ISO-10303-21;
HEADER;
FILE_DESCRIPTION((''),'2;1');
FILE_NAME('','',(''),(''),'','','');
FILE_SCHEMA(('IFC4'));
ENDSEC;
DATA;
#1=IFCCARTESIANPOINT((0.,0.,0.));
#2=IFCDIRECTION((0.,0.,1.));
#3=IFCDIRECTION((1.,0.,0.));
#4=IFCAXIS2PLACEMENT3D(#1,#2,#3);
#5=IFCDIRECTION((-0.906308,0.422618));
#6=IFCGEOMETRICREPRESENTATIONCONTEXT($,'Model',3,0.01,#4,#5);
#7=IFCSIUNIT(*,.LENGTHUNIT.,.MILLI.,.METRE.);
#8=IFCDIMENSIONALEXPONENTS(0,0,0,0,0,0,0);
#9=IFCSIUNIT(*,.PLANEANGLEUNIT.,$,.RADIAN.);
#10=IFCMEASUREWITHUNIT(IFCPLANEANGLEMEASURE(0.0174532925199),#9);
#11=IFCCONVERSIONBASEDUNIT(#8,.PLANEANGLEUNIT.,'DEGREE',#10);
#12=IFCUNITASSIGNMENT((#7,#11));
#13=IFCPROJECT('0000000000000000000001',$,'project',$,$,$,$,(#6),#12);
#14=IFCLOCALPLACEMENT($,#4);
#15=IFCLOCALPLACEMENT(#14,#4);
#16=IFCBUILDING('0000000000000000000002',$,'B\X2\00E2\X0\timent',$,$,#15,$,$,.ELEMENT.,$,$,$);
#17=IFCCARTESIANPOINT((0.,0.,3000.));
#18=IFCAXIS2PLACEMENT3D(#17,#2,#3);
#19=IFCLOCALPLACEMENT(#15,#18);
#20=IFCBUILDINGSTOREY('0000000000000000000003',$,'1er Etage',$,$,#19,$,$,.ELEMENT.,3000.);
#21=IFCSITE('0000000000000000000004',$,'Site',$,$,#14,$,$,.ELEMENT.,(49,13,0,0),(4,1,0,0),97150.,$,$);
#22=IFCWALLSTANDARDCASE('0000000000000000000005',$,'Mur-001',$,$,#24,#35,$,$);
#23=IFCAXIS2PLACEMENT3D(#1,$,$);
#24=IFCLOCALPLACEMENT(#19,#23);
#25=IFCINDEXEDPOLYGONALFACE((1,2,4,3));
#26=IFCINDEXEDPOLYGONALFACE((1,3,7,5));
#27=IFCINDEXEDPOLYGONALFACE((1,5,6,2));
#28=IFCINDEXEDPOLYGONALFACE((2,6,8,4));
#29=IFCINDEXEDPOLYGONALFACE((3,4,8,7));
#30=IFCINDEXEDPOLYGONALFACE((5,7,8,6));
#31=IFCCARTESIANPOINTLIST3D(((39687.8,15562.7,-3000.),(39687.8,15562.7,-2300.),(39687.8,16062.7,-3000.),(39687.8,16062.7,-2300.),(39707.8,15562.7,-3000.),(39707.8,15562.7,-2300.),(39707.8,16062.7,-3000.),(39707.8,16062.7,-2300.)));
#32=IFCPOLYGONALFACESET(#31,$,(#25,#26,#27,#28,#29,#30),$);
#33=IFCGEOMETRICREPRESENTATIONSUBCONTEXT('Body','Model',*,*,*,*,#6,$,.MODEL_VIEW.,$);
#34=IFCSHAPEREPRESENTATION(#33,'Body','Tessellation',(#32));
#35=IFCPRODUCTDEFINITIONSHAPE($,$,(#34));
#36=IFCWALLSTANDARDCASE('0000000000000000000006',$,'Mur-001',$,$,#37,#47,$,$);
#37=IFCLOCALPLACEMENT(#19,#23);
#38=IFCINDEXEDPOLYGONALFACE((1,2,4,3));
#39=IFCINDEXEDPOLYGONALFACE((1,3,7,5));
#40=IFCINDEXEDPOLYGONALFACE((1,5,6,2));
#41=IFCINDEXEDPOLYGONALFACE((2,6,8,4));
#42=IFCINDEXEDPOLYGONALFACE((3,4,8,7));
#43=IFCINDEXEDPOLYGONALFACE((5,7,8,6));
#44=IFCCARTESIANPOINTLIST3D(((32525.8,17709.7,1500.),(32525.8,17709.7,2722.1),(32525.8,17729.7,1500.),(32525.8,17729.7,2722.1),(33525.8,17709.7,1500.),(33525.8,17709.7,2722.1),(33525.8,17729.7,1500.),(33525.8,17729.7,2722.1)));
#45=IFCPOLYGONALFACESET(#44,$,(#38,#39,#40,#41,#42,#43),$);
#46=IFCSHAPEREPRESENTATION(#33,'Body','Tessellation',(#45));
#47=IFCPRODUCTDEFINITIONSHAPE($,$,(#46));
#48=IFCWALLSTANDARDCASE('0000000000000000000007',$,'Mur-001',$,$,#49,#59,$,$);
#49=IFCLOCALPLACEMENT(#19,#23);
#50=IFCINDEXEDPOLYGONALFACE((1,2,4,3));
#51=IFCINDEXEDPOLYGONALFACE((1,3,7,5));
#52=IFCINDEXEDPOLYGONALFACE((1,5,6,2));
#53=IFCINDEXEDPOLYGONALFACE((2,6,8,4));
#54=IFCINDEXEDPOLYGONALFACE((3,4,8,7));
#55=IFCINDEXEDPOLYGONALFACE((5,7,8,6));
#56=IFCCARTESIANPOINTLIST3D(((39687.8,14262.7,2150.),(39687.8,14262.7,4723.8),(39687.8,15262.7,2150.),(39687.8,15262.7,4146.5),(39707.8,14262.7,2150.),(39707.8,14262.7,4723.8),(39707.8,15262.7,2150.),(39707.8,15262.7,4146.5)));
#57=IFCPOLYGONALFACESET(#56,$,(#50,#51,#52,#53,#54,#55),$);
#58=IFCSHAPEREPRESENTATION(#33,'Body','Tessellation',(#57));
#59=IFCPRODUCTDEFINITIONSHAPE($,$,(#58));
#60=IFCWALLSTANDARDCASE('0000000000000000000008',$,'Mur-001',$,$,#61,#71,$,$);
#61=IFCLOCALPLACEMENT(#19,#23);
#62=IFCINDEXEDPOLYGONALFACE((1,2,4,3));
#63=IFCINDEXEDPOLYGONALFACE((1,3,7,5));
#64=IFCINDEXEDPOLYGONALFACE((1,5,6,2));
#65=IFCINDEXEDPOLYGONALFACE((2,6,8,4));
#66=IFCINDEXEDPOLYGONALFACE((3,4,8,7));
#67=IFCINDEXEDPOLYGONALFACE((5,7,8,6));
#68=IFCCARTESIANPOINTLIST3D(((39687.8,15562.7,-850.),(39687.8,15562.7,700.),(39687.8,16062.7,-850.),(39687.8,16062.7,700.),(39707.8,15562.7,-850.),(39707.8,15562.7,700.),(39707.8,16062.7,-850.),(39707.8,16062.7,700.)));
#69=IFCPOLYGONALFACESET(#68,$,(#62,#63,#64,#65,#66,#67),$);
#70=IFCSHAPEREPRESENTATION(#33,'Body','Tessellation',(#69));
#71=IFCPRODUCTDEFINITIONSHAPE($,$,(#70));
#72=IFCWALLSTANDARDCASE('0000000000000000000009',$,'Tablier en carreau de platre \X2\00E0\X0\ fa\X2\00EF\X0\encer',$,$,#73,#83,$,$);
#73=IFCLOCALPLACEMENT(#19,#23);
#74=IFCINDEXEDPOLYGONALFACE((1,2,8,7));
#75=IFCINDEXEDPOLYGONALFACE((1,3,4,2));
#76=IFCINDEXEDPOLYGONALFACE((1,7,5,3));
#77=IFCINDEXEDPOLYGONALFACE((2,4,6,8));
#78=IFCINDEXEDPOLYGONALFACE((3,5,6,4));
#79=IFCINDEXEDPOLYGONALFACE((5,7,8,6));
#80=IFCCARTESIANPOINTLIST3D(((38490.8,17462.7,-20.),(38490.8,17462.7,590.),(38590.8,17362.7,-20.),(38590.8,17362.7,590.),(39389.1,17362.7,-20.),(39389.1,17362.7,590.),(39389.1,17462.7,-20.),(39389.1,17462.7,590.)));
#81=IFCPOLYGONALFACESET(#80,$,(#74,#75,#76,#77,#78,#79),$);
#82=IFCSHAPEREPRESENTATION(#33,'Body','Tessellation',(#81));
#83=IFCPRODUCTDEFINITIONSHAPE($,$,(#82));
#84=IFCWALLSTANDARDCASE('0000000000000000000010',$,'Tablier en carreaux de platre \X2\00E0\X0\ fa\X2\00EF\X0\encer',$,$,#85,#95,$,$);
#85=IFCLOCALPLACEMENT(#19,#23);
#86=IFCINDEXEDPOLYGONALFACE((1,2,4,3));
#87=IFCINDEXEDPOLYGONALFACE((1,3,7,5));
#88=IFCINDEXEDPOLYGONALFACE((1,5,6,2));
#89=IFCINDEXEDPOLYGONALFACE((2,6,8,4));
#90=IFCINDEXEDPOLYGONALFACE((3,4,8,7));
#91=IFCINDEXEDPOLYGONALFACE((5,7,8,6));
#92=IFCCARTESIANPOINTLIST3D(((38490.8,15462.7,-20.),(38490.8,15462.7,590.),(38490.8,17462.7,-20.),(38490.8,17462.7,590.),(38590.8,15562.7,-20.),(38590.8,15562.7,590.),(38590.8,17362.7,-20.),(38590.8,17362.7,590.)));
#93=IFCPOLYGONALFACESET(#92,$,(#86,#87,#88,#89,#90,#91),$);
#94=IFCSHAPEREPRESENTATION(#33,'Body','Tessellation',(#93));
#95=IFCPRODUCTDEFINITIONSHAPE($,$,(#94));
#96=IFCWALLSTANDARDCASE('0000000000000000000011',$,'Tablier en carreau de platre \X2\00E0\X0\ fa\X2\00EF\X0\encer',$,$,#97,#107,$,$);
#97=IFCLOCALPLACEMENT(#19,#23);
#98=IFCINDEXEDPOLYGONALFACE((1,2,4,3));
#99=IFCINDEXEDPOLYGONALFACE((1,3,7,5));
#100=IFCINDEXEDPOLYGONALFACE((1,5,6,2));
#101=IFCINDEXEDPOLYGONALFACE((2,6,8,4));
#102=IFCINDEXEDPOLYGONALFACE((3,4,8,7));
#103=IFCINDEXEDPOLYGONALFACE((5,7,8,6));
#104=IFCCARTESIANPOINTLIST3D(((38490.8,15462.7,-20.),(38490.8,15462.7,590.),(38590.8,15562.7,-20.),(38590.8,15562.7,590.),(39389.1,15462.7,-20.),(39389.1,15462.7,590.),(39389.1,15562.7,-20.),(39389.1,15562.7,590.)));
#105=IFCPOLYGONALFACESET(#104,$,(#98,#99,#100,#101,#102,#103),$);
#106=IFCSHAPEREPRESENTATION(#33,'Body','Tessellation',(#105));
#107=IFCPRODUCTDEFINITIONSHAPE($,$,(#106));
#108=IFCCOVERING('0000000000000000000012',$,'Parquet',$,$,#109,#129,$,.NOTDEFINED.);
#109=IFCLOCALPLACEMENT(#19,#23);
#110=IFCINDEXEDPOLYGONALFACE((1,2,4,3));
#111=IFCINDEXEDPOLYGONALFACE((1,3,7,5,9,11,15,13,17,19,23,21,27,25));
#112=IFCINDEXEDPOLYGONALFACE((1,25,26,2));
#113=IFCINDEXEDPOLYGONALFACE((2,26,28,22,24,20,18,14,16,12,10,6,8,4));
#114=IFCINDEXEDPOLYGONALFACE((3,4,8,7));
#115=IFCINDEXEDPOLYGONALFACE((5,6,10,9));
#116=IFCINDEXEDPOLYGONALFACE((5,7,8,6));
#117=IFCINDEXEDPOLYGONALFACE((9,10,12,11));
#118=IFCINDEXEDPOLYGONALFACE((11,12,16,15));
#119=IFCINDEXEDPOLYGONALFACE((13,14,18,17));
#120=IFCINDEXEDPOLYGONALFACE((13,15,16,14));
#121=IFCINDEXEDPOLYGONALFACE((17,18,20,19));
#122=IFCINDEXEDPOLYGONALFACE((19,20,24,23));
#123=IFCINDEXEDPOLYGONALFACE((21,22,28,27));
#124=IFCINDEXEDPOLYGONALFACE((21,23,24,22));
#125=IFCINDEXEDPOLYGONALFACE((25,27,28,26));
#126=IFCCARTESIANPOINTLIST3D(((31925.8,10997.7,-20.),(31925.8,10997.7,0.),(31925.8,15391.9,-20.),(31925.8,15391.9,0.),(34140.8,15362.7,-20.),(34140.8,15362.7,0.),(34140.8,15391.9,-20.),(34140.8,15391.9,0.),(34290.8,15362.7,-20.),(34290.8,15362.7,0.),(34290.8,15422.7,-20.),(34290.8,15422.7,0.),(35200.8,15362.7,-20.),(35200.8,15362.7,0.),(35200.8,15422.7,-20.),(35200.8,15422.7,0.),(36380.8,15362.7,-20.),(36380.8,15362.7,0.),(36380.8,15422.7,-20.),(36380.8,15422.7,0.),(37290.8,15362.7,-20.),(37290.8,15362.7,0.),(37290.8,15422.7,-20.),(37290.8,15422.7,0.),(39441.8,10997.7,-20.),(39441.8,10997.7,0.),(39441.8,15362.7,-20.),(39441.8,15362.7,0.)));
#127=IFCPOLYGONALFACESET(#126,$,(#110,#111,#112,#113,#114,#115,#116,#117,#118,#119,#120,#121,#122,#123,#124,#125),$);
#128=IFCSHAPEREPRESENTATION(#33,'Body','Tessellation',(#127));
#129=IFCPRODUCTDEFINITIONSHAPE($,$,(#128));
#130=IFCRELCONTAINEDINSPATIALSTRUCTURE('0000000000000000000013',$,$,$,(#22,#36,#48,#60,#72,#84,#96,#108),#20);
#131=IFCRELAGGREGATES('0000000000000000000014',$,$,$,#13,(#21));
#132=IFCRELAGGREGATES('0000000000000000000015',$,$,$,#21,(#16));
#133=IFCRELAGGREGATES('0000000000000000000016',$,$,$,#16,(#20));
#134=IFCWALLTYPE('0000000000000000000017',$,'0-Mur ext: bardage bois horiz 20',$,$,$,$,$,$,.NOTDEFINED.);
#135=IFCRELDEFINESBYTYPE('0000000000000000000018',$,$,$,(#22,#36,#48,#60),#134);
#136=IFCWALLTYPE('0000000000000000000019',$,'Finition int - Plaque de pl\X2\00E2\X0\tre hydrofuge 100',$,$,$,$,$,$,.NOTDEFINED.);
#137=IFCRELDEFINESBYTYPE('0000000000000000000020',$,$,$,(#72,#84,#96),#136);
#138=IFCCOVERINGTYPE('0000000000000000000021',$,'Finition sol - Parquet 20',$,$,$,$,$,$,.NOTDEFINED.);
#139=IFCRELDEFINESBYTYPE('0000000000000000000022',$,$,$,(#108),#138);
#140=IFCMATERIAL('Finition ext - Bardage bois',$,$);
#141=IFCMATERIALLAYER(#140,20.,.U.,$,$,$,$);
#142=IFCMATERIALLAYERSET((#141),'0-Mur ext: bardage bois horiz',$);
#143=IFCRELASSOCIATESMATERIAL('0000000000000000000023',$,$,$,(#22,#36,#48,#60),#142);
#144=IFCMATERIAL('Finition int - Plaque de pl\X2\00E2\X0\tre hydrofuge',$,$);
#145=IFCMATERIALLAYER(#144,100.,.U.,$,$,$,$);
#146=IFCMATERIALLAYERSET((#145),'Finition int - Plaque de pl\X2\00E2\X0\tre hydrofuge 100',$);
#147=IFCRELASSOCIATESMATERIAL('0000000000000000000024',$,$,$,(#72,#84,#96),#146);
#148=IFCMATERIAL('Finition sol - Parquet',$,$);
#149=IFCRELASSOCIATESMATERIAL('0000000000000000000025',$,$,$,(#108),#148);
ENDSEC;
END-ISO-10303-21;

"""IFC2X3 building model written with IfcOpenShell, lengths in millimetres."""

from ifc_helpers import new_model, entity, si_unit, converted_unit, direction, frame, origin_with_axes, place, context, subcontext, project, spatial, polyline, outline, extrude, clip, halfspace, material, layer, layer_set, layer_usage, type_object, element, save


model = new_model("IFC2X3")

# Units and contexts
model_context = context("Model", 3, precision=0.01, world=origin_with_axes(), true_north=direction((-0.906308, 0.422618)))
body_context = subcontext(model_context, "Body", "Model", "MODEL_VIEW")
ifc_project = project(units=[si_unit("LENGTHUNIT", "METRE", prefix="MILLI"), converted_unit("PLANEANGLEUNIT", "DEGREE", entity("IfcPlaneAngleMeasure", 0.0174532925199), si_unit("PLANEANGLEUNIT", "RADIAN"), dimensions=[0, 0, 0, 0, 0, 0, 0])], contexts=[model_context])

# Site, building, storey
site_placement = place(None, origin_with_axes())
site = spatial("IfcSite", under=ifc_project, at=site_placement, Name="Site", CompositionType="ELEMENT", RefLatitude=(49, 13, 0, 0), RefLongitude=(4, 1, 0, 0), RefElevation=97150.0)
building_placement = place(site_placement, origin_with_axes())
building = spatial("IfcBuilding", under=site, at=building_placement, Name="Bâtiment", CompositionType="ELEMENT")
storey_placement = place(building_placement, frame((0.0, 0.0, 3000.0), z_axis=(0.0, 0.0, 1.0), x_axis=(1.0, 0.0, 0.0)))
storey = spatial("IfcBuildingStorey", under=building, at=storey_placement, Name="1er Etage", CompositionType="ELEMENT", Elevation=3000.0)

# Walls
ifc_material_1 = material(Name="Finition ext - Bardage bois")
ifc_layer_1 = layer(ifc_material_1, 20.0, ventilated="UNKNOWN")
ifc_layer_set_1 = layer_set([ifc_layer_1], Name="0-Mur ext: bardage bois horiz")
ifc_layer_usage_1 = layer_usage(ifc_layer_set_1, "AXIS2", "POSITIVE", 0.0)
wall_type_1 = type_object("IfcWallType", Name="0-Mur ext: bardage bois horiz 20", PredefinedType="NOTDEFINED")
wall_1_placement = place(storey_placement, frame((39707.8, 15562.7, -3000.0), z_axis=(0.0, 0.0, 1.0), x_axis=(0.0, 1.0, 0.0)))
element("IfcWallStandardCase", 1, at=wall_1_placement, inside=storey, type_object=wall_type_1, material=ifc_layer_usage_1, Name="Mur-001", context=body_context, shape_type="SweptSolid", body=[
    extrude(outline(polyline([(0.0, 0.0), (500.0, 0.0), (500.0, 20.0), (0.0, 20.0), (0.0, 0.0)])), origin_with_axes(), (0.0, 0.0, 1.0), 700.0),
])
ifc_layer_usage_2 = layer_usage(ifc_layer_set_1, "AXIS2", "NEGATIVE", 0.0)
wall_2_placement = place(storey_placement, frame((32525.8, 17729.7, 1500.0), z_axis=(0.0, 0.0, 1.0), x_axis=(1.0, 0.0, 0.0)))
element("IfcWallStandardCase", 2, at=wall_2_placement, inside=storey, type_object=wall_type_1, material=ifc_layer_usage_2, Name="Mur-001", context=body_context, shape_type="SweptSolid", body=[
    extrude(outline(polyline([(0.0, -20.0), (1000.0, -20.0), (1000.0, 0.0), (0.0, 0.0), (0.0, -20.0)])), origin_with_axes(), (0.0, 0.0, 1.0), 1222.1),
])
ifc_layer_usage_3 = layer_usage(ifc_layer_set_1, "AXIS2", "POSITIVE", 0.0)
wall_3_placement = place(storey_placement, frame((39707.8, 14262.7, 2150.0), z_axis=(0.0, 0.0, 1.0), x_axis=(0.0, 1.0, 0.0)))
element("IfcWallStandardCase", 3, at=wall_3_placement, inside=storey, type_object=wall_type_1, material=ifc_layer_usage_3, Name="Mur-001", context=body_context, shape_type="Clipping", body=[
    clip(extrude(outline(polyline([(0.0, 0.0), (1000.0, 0.0), (1000.0, 20.0), (0.0, 20.0), (0.0, 0.0)])), origin_with_axes(), (0.0, 0.0, 1.0), 3050.0), halfspace(frame((1114.5, 0.0, 1930.4), z_axis=(-0.5, 0.0, -0.866025), x_axis=(0.0, 1.0, 0.0)), True)),
])
ifc_layer_usage_4 = layer_usage(ifc_layer_set_1, "AXIS2", "POSITIVE", 0.0)
wall_4_placement = place(storey_placement, frame((39707.8, 15562.7, -850.0), z_axis=(0.0, 0.0, 1.0), x_axis=(0.0, 1.0, 0.0)))
element("IfcWallStandardCase", 4, at=wall_4_placement, inside=storey, type_object=wall_type_1, material=ifc_layer_usage_4, Name="Mur-001", context=body_context, shape_type="SweptSolid", body=[
    extrude(outline(polyline([(0.0, 0.0), (500.0, 0.0), (500.0, 20.0), (0.0, 20.0), (0.0, 0.0)])), origin_with_axes(), (0.0, 0.0, 1.0), 1550.0),
])
ifc_material_2 = material(Name="Finition int - Plaque de plâtre hydrofuge")
ifc_layer_2 = layer(ifc_material_2, 100.0, ventilated="UNKNOWN")
ifc_layer_set_2 = layer_set([ifc_layer_2], Name="Finition int - Plaque de plâtre hydrofuge 100")
ifc_layer_usage_5 = layer_usage(ifc_layer_set_2, "AXIS2", "POSITIVE", -100.0)
wall_type_2 = type_object("IfcWallType", Name="Finition int - Plaque de plâtre hydrofuge 100", PredefinedType="NOTDEFINED")
wall_5_placement = place(storey_placement, frame((39389.1, 17362.7, -20.0), z_axis=(0.0, 0.0, 1.0), x_axis=(-1.0, 0.0, 0.0)))
element("IfcWallStandardCase", 5, at=wall_5_placement, inside=storey, type_object=wall_type_2, material=ifc_layer_usage_5, Name="Tablier en carreau de platre à faïencer", context=body_context, shape_type="SweptSolid", body=[
    extrude(outline(polyline([(0.0, -100.0), (898.2, -100.0), (798.2, 0.0), (0.0, 0.0), (0.0, -100.0)])), origin_with_axes(), (0.0, 0.0, 1.0), 610.0),
])
ifc_layer_usage_6 = layer_usage(ifc_layer_set_2, "AXIS2", "POSITIVE", -100.0)
wall_6_placement = place(storey_placement, frame((38590.8, 17362.7, -20.0), z_axis=(0.0, 0.0, 1.0), x_axis=(0.0, -1.0, 0.0)))
element("IfcWallStandardCase", 6, at=wall_6_placement, inside=storey, type_object=wall_type_2, material=ifc_layer_usage_6, Name="Tablier en carreaux de platre à faïencer", context=body_context, shape_type="SweptSolid", body=[
    extrude(outline(polyline([(-100.0, -100.0), (1900.0, -100.0), (1800.0, 0.0), (0.0, 0.0), (-100.0, -100.0)])), origin_with_axes(), (0.0, 0.0, 1.0), 610.0),
])
ifc_layer_usage_7 = layer_usage(ifc_layer_set_2, "AXIS2", "POSITIVE", -100.0)
wall_7_placement = place(storey_placement, frame((38590.8, 15562.7, -20.0), z_axis=(0.0, 0.0, 1.0), x_axis=(1.0, 0.0, 0.0)))
element("IfcWallStandardCase", 7, at=wall_7_placement, inside=storey, type_object=wall_type_2, material=ifc_layer_usage_7, Name="Tablier en carreau de platre à faïencer", context=body_context, shape_type="SweptSolid", body=[
    extrude(outline(polyline([(-100.0, -100.0), (798.2, -100.0), (798.2, 0.0), (0.0, 0.0), (-100.0, -100.0)])), origin_with_axes(), (0.0, 0.0, 1.0), 610.0),
])

# Covering
ifc_material_3 = material(Name="Finition sol - Parquet")
covering_type = type_object("IfcCoveringType", Name="Finition sol - Parquet 20", PredefinedType="NOTDEFINED")
covering_placement = place(storey_placement, frame((31925.8, 15391.9, 0.0), z_axis=(0.0, 0.0, 1.0), x_axis=(1.0, 0.0, 0.0)))
element("IfcCovering", 8, at=covering_placement, inside=storey, type_object=covering_type, material=ifc_material_3, Name="Parquet", PredefinedType="NOTDEFINED", context=body_context, shape_type="SweptSolid", body=[
    extrude(outline(polyline([(0.0, 0.0), (0.0, -4394.3), (7516.0, -4394.3), (7516.0, -29.3), (5365.0, -29.3), (5365.0, 30.7), (4455.0, 30.7), (4455.0, -29.3), (3275.0, -29.3), (3275.0, 30.7), (2365.0, 30.7), (2365.0, -29.3), (2215.0, -29.3), (2215.0, 0.0), (0.0, 0.0)])), frame((0.0, 0.0, -20.0), z_axis=(0.0, 0.0, 1.0), x_axis=(1.0, 0.0, 0.0)), (0.0, 0.0, 1.0), 20.0),
])

save(model, "model.ifc")
